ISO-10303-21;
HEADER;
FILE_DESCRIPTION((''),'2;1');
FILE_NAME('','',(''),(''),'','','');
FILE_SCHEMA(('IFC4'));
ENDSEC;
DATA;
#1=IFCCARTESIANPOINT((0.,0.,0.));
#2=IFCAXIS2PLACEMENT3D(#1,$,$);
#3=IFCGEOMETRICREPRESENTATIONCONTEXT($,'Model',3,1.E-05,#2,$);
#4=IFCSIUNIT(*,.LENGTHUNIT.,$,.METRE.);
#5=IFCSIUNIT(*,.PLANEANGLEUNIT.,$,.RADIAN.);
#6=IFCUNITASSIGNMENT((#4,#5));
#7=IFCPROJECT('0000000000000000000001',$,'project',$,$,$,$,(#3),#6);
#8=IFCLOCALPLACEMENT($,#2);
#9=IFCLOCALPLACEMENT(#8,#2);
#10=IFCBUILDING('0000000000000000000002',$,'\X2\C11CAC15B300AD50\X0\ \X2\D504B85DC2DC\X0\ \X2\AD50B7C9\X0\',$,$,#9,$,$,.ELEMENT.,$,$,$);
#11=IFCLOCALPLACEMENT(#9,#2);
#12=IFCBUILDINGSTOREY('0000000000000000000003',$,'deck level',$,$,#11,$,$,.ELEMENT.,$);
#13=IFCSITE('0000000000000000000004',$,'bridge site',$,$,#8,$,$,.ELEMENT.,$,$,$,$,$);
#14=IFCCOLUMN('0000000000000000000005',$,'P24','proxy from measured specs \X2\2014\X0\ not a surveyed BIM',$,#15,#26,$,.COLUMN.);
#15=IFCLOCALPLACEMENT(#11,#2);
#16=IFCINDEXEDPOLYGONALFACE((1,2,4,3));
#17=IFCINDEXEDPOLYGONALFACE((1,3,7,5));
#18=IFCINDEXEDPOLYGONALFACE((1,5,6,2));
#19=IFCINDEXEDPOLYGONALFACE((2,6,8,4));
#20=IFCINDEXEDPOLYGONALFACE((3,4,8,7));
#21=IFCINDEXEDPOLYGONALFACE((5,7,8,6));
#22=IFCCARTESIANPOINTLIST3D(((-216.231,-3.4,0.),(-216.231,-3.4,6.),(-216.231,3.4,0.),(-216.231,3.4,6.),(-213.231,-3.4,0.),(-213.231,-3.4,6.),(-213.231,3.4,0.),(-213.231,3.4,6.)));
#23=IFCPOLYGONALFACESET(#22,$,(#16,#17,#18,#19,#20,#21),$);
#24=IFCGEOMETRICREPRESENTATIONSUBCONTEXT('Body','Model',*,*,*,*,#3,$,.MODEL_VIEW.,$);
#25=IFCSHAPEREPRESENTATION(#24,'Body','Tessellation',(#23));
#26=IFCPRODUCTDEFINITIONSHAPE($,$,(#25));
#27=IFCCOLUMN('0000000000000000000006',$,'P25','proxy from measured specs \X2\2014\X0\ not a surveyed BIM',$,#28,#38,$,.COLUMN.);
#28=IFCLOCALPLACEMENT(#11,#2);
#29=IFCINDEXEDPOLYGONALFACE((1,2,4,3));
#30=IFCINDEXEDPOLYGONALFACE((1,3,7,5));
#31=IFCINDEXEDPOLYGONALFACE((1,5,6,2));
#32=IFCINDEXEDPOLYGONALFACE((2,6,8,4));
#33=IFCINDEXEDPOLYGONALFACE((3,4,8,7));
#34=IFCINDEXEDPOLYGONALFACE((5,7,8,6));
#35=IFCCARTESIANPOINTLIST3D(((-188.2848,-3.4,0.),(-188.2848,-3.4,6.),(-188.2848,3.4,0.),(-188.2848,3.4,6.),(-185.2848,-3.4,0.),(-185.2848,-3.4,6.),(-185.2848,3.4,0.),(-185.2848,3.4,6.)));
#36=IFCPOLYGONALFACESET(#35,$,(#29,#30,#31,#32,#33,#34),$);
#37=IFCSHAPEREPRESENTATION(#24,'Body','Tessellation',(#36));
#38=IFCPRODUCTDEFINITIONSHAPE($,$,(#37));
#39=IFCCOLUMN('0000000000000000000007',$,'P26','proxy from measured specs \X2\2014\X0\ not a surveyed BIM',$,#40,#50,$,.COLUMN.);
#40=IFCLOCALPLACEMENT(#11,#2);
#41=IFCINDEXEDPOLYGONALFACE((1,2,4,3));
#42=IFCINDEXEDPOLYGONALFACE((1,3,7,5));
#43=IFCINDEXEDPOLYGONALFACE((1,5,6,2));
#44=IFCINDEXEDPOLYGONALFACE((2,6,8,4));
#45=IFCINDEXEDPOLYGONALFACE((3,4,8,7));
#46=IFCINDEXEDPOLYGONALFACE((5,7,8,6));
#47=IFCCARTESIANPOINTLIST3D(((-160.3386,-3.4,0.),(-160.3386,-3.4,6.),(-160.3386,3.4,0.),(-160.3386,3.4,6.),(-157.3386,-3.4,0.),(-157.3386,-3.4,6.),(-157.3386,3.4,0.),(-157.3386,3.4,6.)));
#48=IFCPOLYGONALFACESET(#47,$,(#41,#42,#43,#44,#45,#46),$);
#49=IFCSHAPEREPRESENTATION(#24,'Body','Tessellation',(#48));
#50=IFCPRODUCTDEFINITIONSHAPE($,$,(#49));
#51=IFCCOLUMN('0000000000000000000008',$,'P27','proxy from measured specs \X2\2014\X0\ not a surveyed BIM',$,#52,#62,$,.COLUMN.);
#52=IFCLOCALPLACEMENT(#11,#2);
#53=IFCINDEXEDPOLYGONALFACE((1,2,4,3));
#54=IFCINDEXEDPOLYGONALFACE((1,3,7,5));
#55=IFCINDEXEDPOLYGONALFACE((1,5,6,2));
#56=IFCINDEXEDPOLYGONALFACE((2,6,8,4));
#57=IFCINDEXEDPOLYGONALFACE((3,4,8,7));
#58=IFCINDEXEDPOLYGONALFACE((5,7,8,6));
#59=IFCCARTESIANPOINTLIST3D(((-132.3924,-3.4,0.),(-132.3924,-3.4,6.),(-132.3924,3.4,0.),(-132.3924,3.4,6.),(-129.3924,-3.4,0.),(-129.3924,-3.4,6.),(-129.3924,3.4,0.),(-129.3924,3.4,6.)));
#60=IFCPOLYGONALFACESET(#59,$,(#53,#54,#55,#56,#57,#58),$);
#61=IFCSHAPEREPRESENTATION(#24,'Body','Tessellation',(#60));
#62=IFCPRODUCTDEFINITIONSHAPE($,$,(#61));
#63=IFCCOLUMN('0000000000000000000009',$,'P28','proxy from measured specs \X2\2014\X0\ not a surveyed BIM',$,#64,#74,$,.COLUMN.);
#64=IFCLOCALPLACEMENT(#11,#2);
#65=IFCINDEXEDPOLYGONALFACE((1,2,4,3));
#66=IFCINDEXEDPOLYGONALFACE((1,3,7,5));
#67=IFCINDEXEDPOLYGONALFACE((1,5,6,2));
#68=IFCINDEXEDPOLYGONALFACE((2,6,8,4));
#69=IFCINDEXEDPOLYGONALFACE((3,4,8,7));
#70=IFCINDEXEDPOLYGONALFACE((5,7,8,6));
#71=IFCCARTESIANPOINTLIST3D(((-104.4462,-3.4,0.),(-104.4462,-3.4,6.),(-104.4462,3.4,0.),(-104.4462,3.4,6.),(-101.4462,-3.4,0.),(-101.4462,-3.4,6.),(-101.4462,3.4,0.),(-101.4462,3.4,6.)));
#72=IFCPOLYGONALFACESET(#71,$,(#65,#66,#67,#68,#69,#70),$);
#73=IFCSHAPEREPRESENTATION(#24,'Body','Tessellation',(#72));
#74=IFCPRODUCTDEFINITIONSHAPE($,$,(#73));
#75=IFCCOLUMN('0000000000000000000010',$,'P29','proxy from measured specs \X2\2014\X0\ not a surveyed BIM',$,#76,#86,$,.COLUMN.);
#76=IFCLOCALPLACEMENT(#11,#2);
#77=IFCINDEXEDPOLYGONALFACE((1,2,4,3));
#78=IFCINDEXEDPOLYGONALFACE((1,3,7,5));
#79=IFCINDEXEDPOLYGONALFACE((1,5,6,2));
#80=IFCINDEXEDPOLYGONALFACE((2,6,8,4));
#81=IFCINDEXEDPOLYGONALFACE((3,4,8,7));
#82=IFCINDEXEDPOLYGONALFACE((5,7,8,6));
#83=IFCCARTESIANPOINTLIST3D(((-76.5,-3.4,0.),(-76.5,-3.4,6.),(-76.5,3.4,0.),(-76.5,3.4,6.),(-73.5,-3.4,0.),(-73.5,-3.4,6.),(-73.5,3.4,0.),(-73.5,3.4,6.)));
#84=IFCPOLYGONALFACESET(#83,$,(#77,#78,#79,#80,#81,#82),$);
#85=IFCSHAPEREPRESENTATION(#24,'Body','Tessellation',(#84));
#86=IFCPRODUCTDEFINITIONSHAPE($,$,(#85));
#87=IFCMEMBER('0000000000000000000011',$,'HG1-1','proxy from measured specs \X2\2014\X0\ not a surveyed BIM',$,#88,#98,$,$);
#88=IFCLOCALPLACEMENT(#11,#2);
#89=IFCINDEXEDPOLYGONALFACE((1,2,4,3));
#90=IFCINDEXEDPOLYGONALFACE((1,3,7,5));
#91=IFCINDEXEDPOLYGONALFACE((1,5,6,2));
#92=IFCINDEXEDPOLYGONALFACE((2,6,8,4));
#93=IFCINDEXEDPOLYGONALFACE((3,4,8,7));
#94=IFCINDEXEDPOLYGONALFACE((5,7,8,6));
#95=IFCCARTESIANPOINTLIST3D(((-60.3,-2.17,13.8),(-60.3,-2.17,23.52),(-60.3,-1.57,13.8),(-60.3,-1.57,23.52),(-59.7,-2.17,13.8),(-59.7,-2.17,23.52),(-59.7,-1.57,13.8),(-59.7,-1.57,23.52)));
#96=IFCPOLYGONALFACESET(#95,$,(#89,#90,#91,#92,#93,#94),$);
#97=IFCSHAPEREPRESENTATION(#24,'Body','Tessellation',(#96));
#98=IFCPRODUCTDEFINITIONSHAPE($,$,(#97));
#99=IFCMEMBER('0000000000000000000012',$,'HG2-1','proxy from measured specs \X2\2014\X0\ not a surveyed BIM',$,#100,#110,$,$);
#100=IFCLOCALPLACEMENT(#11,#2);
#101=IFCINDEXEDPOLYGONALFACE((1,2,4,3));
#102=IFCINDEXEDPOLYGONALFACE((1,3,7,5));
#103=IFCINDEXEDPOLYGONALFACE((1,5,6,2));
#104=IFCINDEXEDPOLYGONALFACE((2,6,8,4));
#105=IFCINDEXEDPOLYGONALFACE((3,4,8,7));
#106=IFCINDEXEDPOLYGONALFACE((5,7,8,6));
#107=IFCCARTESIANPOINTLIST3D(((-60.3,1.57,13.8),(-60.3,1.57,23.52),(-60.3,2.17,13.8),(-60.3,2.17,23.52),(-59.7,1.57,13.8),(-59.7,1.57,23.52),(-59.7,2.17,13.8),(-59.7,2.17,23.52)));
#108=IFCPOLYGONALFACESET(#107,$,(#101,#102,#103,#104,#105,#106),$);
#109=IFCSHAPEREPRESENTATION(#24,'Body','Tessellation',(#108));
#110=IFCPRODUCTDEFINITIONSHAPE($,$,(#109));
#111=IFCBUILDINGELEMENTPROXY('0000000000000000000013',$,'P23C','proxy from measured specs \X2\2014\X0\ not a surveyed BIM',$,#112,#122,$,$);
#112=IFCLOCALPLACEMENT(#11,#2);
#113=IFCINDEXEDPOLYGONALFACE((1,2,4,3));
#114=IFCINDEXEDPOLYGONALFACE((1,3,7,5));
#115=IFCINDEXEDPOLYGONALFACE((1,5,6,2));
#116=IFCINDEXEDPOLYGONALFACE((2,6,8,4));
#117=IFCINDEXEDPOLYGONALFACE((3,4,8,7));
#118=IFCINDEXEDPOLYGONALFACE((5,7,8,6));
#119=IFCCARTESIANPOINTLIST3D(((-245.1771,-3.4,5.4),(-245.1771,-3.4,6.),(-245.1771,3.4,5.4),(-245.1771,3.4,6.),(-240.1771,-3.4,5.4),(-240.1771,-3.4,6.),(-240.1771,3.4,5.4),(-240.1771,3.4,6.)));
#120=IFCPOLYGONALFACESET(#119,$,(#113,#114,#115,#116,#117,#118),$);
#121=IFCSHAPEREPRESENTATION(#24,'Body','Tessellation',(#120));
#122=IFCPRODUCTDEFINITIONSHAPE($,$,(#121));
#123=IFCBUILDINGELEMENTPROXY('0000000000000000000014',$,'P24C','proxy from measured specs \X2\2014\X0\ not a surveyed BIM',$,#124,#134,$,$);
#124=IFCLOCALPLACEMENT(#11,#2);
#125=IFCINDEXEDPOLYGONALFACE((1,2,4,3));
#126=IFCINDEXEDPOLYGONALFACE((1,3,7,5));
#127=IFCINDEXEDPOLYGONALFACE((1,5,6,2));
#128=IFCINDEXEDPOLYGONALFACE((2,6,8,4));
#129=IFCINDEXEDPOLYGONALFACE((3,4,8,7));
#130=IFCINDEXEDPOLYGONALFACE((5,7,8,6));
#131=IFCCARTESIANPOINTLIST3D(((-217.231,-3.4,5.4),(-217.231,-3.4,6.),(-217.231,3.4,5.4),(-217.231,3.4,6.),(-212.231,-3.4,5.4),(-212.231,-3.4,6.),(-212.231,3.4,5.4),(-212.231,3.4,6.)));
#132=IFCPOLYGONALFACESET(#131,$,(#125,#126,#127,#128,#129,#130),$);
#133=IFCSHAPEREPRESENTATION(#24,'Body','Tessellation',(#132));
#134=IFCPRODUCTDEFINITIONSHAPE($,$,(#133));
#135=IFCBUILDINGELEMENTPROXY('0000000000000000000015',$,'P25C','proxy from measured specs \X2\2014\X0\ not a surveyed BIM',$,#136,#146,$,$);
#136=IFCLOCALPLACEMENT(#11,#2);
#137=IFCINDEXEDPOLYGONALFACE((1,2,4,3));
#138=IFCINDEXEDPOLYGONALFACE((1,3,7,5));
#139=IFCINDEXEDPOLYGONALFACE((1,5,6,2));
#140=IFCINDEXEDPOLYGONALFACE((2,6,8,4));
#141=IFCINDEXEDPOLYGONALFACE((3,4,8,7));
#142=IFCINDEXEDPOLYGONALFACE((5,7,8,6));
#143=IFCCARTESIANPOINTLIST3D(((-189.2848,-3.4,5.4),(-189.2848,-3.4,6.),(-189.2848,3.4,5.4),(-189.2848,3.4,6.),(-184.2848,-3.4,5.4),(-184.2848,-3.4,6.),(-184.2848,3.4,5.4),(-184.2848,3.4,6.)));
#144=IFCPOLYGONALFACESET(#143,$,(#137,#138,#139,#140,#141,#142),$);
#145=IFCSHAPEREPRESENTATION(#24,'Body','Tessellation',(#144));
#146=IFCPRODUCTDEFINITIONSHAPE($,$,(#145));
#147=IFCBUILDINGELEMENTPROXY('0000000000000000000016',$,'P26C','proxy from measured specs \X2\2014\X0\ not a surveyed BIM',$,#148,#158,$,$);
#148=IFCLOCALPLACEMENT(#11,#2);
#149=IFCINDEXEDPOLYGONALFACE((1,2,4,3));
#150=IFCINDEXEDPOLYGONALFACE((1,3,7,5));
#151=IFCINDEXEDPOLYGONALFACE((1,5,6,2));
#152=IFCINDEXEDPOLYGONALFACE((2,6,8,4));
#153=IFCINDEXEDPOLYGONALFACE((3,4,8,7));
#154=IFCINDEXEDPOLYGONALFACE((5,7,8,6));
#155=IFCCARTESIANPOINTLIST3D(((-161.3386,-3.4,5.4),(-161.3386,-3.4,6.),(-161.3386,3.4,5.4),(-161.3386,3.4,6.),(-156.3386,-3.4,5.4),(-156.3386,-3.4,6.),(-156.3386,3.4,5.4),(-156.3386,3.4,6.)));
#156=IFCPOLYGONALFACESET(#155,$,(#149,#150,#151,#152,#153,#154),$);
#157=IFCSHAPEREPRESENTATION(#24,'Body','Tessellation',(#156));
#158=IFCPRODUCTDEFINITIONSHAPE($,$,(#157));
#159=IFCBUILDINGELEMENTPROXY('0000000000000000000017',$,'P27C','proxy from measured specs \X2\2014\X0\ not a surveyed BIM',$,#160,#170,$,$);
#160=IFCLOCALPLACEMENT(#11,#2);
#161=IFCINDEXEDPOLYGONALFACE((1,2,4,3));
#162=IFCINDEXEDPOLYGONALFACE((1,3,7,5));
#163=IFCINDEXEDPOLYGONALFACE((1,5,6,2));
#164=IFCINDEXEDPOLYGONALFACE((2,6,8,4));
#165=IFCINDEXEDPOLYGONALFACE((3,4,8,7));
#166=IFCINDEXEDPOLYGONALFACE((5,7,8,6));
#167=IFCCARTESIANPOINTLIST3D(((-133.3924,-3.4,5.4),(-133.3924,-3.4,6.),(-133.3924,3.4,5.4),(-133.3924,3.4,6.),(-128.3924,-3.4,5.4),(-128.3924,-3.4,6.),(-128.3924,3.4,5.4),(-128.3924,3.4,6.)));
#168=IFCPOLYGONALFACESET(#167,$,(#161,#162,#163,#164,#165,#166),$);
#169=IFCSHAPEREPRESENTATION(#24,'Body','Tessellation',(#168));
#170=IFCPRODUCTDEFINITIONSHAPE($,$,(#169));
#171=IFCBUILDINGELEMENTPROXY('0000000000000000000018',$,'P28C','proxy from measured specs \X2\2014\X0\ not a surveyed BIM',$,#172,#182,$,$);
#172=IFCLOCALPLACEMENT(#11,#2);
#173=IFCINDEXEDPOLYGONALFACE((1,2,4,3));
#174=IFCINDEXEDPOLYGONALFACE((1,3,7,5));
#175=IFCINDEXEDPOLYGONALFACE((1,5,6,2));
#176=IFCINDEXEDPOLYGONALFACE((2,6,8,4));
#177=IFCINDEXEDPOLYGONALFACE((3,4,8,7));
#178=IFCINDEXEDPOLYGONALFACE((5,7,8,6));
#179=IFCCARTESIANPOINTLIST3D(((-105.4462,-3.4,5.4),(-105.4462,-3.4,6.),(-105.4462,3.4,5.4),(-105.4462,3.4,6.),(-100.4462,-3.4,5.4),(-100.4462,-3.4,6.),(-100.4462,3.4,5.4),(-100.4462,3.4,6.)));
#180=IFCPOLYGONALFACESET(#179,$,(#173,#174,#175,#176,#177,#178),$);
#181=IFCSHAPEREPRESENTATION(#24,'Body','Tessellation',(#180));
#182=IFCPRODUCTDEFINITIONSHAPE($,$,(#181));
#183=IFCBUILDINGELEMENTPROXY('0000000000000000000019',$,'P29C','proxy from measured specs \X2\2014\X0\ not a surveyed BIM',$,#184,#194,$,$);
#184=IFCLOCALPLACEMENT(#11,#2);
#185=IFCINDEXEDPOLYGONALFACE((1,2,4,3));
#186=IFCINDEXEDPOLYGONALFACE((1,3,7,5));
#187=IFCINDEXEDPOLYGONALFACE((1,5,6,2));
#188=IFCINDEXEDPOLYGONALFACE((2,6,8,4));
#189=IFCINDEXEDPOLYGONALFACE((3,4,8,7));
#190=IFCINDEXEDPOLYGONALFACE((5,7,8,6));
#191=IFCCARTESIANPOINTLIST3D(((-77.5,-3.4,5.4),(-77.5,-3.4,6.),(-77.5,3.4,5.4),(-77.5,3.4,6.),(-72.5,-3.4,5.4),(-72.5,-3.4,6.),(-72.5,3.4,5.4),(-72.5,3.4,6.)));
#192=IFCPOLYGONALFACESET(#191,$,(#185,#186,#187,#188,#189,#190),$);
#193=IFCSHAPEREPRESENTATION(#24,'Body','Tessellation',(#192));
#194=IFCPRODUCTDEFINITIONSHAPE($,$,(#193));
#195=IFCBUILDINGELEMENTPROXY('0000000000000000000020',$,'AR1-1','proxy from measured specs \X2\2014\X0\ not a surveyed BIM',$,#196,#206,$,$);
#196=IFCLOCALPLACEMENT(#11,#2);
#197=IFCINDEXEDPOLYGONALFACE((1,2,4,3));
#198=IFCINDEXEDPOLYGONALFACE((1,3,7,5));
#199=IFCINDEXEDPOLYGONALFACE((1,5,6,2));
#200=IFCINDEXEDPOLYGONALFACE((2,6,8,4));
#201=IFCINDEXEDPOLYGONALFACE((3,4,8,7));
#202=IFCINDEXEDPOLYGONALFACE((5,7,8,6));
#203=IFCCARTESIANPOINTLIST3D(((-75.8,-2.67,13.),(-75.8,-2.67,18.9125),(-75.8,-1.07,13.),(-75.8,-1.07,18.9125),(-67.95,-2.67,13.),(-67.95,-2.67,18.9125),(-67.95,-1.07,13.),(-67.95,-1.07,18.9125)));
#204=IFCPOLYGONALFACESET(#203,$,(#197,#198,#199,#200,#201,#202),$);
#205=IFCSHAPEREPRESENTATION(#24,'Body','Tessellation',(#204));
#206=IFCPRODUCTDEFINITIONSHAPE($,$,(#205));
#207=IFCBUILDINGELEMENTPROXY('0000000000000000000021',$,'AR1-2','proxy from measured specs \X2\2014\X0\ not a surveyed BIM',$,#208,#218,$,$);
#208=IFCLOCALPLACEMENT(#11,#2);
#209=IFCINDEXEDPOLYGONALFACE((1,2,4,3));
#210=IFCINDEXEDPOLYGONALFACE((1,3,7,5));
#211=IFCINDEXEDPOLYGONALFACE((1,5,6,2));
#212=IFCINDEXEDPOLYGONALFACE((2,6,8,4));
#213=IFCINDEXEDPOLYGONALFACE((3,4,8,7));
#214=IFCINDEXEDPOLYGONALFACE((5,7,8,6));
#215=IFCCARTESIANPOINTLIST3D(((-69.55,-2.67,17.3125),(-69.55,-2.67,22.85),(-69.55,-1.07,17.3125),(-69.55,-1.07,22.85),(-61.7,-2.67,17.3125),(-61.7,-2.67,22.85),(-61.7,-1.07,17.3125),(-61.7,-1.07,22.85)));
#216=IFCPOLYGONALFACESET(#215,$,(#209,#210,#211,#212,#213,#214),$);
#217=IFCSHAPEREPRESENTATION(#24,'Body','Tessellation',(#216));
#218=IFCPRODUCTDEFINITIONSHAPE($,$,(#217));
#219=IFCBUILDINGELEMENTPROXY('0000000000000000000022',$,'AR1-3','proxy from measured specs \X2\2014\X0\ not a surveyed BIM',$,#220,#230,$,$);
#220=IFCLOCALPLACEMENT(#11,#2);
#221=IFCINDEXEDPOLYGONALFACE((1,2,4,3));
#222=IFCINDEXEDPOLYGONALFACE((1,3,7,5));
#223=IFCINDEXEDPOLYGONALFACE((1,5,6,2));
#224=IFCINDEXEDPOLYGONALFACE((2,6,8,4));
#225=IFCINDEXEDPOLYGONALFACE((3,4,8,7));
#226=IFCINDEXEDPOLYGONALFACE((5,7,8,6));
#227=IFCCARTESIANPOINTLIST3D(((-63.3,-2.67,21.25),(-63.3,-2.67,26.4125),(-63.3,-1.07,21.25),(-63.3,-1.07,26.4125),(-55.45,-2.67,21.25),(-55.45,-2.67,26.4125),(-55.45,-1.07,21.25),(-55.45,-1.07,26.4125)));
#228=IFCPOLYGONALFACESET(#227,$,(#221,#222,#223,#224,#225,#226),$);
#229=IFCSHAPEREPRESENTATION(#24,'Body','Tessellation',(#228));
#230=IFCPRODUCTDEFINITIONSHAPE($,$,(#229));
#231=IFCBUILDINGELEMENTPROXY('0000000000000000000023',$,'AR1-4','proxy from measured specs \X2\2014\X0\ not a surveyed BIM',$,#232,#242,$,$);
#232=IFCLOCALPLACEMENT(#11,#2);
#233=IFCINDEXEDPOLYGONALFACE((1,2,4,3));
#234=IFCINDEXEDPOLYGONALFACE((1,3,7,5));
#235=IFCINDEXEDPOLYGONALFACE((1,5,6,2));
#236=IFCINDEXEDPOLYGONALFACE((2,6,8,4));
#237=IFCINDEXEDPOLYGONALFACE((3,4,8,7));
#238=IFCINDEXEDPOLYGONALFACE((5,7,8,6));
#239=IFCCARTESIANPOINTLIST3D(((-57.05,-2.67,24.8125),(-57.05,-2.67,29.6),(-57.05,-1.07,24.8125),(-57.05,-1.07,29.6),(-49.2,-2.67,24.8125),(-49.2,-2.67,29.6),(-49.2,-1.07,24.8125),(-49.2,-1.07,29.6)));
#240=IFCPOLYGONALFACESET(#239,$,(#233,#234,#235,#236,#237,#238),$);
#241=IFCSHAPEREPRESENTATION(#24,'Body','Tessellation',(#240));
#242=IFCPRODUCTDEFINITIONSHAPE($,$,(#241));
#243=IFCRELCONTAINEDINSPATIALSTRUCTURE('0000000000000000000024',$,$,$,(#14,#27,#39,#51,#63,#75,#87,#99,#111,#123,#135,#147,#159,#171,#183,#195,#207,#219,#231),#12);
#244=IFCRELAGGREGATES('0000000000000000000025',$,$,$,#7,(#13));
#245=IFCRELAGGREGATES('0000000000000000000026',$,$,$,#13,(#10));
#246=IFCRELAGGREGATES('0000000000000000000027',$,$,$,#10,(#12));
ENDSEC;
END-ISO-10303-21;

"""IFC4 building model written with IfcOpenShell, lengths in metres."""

from ifc_helpers import new_model, si_unit, frame, origin, origin_2d, place, context, subcontext, project, spatial, rectangle, extrude, element, save


model = new_model("IFC4")

# Units and contexts
model_context = context("Model", 3, precision=1e-05, world=origin())
body_context = subcontext(model_context, "Body", "Model", "MODEL_VIEW")
ifc_project = project(units=[si_unit("LENGTHUNIT", "METRE"), si_unit("PLANEANGLEUNIT", "RADIAN")], contexts=[model_context])

# Site, building, storey
site_placement = place(None, origin())
site = spatial("IfcSite", under=ifc_project, at=site_placement, Name="bridge site", CompositionType="ELEMENT")
building_placement = place(site_placement, origin())
building = spatial("IfcBuilding", under=site, at=building_placement, Name="서강대교 프록시 교량", CompositionType="ELEMENT")
storey_placement = place(building_placement, origin())
storey = spatial("IfcBuildingStorey", under=building, at=storey_placement, Name="deck level", CompositionType="ELEMENT")

# Columns
for number, where, name in (
    (1, (-214.731, 0.0, 0.0), "P24"),
    (2, (-186.7848, 0.0, 0.0), "P25"),
    (3, (-158.8386, 0.0, 0.0), "P26"),
    (4, (-130.8924, 0.0, 0.0), "P27"),
    (5, (-102.9462, 0.0, 0.0), "P28"),
    (6, (-75.0, 0.0, 0.0), "P29"),
):
    element("IfcColumn", number, at=place(storey_placement, frame(where)), inside=storey, Name=name, Description="proxy from measured specs — not a surveyed BIM", PredefinedType="COLUMN", context=body_context, shape_type="SweptSolid", body=[
        extrude(rectangle(XDim=3.0, YDim=6.8, at=origin_2d()), origin(), (0.0, 0.0, 1.0), 6.0),
    ])

# Members
for number, where, name in (
    (7, (-60.0, -1.87, 13.8), "HG1-1"),
    (8, (-60.0, 1.87, 13.8), "HG2-1"),
):
    element("IfcMember", number, at=place(storey_placement, frame(where)), inside=storey, Name=name, Description="proxy from measured specs — not a surveyed BIM", context=body_context, shape_type="SweptSolid", body=[
        extrude(rectangle(XDim=0.6, YDim=0.6, at=origin_2d()), origin(), (0.0, 0.0, 1.0), 9.72),
    ])

# Building element proxies
for number, where, name in (
    (9, (-242.6771, 0.0, 5.4), "P23C"),
    (10, (-214.731, 0.0, 5.4), "P24C"),
    (11, (-186.7848, 0.0, 5.4), "P25C"),
    (12, (-158.8386, 0.0, 5.4), "P26C"),
    (13, (-130.8924, 0.0, 5.4), "P27C"),
    (14, (-102.9462, 0.0, 5.4), "P28C"),
    (15, (-75.0, 0.0, 5.4), "P29C"),
):
    element("IfcBuildingElementProxy", number, at=place(storey_placement, frame(where)), inside=storey, Name=name, Description="proxy from measured specs — not a surveyed BIM", context=body_context, shape_type="SweptSolid", body=[
        extrude(rectangle(XDim=5.0, YDim=6.8, at=origin_2d()), origin(), (0.0, 0.0, 1.0), 0.6),
    ])
proxy_1_placement = place(storey_placement, frame((-71.875, -1.87, 13.0)))
element("IfcBuildingElementProxy", 16, at=proxy_1_placement, inside=storey, Name="AR1-1", Description="proxy from measured specs — not a surveyed BIM", context=body_context, shape_type="SweptSolid", body=[
    extrude(rectangle(XDim=7.85, YDim=1.6, at=origin_2d()), origin(), (0.0, 0.0, 1.0), 5.9125),
])
proxy_2_placement = place(storey_placement, frame((-65.625, -1.87, 17.3125)))
element("IfcBuildingElementProxy", 17, at=proxy_2_placement, inside=storey, Name="AR1-2", Description="proxy from measured specs — not a surveyed BIM", context=body_context, shape_type="SweptSolid", body=[
    extrude(rectangle(XDim=7.85, YDim=1.6, at=origin_2d()), origin(), (0.0, 0.0, 1.0), 5.5375),
])
proxy_3_placement = place(storey_placement, frame((-59.375, -1.87, 21.25)))
element("IfcBuildingElementProxy", 18, at=proxy_3_placement, inside=storey, Name="AR1-3", Description="proxy from measured specs — not a surveyed BIM", context=body_context, shape_type="SweptSolid", body=[
    extrude(rectangle(XDim=7.85, YDim=1.6, at=origin_2d()), origin(), (0.0, 0.0, 1.0), 5.1625),
])
proxy_4_placement = place(storey_placement, frame((-53.125, -1.87, 24.8125)))
element("IfcBuildingElementProxy", 19, at=proxy_4_placement, inside=storey, Name="AR1-4", Description="proxy from measured specs — not a surveyed BIM", context=body_context, shape_type="SweptSolid", body=[
    extrude(rectangle(XDim=7.85, YDim=1.6, at=origin_2d()), origin(), (0.0, 0.0, 1.0), 4.7875),
])

save(model, "model.ifc")
